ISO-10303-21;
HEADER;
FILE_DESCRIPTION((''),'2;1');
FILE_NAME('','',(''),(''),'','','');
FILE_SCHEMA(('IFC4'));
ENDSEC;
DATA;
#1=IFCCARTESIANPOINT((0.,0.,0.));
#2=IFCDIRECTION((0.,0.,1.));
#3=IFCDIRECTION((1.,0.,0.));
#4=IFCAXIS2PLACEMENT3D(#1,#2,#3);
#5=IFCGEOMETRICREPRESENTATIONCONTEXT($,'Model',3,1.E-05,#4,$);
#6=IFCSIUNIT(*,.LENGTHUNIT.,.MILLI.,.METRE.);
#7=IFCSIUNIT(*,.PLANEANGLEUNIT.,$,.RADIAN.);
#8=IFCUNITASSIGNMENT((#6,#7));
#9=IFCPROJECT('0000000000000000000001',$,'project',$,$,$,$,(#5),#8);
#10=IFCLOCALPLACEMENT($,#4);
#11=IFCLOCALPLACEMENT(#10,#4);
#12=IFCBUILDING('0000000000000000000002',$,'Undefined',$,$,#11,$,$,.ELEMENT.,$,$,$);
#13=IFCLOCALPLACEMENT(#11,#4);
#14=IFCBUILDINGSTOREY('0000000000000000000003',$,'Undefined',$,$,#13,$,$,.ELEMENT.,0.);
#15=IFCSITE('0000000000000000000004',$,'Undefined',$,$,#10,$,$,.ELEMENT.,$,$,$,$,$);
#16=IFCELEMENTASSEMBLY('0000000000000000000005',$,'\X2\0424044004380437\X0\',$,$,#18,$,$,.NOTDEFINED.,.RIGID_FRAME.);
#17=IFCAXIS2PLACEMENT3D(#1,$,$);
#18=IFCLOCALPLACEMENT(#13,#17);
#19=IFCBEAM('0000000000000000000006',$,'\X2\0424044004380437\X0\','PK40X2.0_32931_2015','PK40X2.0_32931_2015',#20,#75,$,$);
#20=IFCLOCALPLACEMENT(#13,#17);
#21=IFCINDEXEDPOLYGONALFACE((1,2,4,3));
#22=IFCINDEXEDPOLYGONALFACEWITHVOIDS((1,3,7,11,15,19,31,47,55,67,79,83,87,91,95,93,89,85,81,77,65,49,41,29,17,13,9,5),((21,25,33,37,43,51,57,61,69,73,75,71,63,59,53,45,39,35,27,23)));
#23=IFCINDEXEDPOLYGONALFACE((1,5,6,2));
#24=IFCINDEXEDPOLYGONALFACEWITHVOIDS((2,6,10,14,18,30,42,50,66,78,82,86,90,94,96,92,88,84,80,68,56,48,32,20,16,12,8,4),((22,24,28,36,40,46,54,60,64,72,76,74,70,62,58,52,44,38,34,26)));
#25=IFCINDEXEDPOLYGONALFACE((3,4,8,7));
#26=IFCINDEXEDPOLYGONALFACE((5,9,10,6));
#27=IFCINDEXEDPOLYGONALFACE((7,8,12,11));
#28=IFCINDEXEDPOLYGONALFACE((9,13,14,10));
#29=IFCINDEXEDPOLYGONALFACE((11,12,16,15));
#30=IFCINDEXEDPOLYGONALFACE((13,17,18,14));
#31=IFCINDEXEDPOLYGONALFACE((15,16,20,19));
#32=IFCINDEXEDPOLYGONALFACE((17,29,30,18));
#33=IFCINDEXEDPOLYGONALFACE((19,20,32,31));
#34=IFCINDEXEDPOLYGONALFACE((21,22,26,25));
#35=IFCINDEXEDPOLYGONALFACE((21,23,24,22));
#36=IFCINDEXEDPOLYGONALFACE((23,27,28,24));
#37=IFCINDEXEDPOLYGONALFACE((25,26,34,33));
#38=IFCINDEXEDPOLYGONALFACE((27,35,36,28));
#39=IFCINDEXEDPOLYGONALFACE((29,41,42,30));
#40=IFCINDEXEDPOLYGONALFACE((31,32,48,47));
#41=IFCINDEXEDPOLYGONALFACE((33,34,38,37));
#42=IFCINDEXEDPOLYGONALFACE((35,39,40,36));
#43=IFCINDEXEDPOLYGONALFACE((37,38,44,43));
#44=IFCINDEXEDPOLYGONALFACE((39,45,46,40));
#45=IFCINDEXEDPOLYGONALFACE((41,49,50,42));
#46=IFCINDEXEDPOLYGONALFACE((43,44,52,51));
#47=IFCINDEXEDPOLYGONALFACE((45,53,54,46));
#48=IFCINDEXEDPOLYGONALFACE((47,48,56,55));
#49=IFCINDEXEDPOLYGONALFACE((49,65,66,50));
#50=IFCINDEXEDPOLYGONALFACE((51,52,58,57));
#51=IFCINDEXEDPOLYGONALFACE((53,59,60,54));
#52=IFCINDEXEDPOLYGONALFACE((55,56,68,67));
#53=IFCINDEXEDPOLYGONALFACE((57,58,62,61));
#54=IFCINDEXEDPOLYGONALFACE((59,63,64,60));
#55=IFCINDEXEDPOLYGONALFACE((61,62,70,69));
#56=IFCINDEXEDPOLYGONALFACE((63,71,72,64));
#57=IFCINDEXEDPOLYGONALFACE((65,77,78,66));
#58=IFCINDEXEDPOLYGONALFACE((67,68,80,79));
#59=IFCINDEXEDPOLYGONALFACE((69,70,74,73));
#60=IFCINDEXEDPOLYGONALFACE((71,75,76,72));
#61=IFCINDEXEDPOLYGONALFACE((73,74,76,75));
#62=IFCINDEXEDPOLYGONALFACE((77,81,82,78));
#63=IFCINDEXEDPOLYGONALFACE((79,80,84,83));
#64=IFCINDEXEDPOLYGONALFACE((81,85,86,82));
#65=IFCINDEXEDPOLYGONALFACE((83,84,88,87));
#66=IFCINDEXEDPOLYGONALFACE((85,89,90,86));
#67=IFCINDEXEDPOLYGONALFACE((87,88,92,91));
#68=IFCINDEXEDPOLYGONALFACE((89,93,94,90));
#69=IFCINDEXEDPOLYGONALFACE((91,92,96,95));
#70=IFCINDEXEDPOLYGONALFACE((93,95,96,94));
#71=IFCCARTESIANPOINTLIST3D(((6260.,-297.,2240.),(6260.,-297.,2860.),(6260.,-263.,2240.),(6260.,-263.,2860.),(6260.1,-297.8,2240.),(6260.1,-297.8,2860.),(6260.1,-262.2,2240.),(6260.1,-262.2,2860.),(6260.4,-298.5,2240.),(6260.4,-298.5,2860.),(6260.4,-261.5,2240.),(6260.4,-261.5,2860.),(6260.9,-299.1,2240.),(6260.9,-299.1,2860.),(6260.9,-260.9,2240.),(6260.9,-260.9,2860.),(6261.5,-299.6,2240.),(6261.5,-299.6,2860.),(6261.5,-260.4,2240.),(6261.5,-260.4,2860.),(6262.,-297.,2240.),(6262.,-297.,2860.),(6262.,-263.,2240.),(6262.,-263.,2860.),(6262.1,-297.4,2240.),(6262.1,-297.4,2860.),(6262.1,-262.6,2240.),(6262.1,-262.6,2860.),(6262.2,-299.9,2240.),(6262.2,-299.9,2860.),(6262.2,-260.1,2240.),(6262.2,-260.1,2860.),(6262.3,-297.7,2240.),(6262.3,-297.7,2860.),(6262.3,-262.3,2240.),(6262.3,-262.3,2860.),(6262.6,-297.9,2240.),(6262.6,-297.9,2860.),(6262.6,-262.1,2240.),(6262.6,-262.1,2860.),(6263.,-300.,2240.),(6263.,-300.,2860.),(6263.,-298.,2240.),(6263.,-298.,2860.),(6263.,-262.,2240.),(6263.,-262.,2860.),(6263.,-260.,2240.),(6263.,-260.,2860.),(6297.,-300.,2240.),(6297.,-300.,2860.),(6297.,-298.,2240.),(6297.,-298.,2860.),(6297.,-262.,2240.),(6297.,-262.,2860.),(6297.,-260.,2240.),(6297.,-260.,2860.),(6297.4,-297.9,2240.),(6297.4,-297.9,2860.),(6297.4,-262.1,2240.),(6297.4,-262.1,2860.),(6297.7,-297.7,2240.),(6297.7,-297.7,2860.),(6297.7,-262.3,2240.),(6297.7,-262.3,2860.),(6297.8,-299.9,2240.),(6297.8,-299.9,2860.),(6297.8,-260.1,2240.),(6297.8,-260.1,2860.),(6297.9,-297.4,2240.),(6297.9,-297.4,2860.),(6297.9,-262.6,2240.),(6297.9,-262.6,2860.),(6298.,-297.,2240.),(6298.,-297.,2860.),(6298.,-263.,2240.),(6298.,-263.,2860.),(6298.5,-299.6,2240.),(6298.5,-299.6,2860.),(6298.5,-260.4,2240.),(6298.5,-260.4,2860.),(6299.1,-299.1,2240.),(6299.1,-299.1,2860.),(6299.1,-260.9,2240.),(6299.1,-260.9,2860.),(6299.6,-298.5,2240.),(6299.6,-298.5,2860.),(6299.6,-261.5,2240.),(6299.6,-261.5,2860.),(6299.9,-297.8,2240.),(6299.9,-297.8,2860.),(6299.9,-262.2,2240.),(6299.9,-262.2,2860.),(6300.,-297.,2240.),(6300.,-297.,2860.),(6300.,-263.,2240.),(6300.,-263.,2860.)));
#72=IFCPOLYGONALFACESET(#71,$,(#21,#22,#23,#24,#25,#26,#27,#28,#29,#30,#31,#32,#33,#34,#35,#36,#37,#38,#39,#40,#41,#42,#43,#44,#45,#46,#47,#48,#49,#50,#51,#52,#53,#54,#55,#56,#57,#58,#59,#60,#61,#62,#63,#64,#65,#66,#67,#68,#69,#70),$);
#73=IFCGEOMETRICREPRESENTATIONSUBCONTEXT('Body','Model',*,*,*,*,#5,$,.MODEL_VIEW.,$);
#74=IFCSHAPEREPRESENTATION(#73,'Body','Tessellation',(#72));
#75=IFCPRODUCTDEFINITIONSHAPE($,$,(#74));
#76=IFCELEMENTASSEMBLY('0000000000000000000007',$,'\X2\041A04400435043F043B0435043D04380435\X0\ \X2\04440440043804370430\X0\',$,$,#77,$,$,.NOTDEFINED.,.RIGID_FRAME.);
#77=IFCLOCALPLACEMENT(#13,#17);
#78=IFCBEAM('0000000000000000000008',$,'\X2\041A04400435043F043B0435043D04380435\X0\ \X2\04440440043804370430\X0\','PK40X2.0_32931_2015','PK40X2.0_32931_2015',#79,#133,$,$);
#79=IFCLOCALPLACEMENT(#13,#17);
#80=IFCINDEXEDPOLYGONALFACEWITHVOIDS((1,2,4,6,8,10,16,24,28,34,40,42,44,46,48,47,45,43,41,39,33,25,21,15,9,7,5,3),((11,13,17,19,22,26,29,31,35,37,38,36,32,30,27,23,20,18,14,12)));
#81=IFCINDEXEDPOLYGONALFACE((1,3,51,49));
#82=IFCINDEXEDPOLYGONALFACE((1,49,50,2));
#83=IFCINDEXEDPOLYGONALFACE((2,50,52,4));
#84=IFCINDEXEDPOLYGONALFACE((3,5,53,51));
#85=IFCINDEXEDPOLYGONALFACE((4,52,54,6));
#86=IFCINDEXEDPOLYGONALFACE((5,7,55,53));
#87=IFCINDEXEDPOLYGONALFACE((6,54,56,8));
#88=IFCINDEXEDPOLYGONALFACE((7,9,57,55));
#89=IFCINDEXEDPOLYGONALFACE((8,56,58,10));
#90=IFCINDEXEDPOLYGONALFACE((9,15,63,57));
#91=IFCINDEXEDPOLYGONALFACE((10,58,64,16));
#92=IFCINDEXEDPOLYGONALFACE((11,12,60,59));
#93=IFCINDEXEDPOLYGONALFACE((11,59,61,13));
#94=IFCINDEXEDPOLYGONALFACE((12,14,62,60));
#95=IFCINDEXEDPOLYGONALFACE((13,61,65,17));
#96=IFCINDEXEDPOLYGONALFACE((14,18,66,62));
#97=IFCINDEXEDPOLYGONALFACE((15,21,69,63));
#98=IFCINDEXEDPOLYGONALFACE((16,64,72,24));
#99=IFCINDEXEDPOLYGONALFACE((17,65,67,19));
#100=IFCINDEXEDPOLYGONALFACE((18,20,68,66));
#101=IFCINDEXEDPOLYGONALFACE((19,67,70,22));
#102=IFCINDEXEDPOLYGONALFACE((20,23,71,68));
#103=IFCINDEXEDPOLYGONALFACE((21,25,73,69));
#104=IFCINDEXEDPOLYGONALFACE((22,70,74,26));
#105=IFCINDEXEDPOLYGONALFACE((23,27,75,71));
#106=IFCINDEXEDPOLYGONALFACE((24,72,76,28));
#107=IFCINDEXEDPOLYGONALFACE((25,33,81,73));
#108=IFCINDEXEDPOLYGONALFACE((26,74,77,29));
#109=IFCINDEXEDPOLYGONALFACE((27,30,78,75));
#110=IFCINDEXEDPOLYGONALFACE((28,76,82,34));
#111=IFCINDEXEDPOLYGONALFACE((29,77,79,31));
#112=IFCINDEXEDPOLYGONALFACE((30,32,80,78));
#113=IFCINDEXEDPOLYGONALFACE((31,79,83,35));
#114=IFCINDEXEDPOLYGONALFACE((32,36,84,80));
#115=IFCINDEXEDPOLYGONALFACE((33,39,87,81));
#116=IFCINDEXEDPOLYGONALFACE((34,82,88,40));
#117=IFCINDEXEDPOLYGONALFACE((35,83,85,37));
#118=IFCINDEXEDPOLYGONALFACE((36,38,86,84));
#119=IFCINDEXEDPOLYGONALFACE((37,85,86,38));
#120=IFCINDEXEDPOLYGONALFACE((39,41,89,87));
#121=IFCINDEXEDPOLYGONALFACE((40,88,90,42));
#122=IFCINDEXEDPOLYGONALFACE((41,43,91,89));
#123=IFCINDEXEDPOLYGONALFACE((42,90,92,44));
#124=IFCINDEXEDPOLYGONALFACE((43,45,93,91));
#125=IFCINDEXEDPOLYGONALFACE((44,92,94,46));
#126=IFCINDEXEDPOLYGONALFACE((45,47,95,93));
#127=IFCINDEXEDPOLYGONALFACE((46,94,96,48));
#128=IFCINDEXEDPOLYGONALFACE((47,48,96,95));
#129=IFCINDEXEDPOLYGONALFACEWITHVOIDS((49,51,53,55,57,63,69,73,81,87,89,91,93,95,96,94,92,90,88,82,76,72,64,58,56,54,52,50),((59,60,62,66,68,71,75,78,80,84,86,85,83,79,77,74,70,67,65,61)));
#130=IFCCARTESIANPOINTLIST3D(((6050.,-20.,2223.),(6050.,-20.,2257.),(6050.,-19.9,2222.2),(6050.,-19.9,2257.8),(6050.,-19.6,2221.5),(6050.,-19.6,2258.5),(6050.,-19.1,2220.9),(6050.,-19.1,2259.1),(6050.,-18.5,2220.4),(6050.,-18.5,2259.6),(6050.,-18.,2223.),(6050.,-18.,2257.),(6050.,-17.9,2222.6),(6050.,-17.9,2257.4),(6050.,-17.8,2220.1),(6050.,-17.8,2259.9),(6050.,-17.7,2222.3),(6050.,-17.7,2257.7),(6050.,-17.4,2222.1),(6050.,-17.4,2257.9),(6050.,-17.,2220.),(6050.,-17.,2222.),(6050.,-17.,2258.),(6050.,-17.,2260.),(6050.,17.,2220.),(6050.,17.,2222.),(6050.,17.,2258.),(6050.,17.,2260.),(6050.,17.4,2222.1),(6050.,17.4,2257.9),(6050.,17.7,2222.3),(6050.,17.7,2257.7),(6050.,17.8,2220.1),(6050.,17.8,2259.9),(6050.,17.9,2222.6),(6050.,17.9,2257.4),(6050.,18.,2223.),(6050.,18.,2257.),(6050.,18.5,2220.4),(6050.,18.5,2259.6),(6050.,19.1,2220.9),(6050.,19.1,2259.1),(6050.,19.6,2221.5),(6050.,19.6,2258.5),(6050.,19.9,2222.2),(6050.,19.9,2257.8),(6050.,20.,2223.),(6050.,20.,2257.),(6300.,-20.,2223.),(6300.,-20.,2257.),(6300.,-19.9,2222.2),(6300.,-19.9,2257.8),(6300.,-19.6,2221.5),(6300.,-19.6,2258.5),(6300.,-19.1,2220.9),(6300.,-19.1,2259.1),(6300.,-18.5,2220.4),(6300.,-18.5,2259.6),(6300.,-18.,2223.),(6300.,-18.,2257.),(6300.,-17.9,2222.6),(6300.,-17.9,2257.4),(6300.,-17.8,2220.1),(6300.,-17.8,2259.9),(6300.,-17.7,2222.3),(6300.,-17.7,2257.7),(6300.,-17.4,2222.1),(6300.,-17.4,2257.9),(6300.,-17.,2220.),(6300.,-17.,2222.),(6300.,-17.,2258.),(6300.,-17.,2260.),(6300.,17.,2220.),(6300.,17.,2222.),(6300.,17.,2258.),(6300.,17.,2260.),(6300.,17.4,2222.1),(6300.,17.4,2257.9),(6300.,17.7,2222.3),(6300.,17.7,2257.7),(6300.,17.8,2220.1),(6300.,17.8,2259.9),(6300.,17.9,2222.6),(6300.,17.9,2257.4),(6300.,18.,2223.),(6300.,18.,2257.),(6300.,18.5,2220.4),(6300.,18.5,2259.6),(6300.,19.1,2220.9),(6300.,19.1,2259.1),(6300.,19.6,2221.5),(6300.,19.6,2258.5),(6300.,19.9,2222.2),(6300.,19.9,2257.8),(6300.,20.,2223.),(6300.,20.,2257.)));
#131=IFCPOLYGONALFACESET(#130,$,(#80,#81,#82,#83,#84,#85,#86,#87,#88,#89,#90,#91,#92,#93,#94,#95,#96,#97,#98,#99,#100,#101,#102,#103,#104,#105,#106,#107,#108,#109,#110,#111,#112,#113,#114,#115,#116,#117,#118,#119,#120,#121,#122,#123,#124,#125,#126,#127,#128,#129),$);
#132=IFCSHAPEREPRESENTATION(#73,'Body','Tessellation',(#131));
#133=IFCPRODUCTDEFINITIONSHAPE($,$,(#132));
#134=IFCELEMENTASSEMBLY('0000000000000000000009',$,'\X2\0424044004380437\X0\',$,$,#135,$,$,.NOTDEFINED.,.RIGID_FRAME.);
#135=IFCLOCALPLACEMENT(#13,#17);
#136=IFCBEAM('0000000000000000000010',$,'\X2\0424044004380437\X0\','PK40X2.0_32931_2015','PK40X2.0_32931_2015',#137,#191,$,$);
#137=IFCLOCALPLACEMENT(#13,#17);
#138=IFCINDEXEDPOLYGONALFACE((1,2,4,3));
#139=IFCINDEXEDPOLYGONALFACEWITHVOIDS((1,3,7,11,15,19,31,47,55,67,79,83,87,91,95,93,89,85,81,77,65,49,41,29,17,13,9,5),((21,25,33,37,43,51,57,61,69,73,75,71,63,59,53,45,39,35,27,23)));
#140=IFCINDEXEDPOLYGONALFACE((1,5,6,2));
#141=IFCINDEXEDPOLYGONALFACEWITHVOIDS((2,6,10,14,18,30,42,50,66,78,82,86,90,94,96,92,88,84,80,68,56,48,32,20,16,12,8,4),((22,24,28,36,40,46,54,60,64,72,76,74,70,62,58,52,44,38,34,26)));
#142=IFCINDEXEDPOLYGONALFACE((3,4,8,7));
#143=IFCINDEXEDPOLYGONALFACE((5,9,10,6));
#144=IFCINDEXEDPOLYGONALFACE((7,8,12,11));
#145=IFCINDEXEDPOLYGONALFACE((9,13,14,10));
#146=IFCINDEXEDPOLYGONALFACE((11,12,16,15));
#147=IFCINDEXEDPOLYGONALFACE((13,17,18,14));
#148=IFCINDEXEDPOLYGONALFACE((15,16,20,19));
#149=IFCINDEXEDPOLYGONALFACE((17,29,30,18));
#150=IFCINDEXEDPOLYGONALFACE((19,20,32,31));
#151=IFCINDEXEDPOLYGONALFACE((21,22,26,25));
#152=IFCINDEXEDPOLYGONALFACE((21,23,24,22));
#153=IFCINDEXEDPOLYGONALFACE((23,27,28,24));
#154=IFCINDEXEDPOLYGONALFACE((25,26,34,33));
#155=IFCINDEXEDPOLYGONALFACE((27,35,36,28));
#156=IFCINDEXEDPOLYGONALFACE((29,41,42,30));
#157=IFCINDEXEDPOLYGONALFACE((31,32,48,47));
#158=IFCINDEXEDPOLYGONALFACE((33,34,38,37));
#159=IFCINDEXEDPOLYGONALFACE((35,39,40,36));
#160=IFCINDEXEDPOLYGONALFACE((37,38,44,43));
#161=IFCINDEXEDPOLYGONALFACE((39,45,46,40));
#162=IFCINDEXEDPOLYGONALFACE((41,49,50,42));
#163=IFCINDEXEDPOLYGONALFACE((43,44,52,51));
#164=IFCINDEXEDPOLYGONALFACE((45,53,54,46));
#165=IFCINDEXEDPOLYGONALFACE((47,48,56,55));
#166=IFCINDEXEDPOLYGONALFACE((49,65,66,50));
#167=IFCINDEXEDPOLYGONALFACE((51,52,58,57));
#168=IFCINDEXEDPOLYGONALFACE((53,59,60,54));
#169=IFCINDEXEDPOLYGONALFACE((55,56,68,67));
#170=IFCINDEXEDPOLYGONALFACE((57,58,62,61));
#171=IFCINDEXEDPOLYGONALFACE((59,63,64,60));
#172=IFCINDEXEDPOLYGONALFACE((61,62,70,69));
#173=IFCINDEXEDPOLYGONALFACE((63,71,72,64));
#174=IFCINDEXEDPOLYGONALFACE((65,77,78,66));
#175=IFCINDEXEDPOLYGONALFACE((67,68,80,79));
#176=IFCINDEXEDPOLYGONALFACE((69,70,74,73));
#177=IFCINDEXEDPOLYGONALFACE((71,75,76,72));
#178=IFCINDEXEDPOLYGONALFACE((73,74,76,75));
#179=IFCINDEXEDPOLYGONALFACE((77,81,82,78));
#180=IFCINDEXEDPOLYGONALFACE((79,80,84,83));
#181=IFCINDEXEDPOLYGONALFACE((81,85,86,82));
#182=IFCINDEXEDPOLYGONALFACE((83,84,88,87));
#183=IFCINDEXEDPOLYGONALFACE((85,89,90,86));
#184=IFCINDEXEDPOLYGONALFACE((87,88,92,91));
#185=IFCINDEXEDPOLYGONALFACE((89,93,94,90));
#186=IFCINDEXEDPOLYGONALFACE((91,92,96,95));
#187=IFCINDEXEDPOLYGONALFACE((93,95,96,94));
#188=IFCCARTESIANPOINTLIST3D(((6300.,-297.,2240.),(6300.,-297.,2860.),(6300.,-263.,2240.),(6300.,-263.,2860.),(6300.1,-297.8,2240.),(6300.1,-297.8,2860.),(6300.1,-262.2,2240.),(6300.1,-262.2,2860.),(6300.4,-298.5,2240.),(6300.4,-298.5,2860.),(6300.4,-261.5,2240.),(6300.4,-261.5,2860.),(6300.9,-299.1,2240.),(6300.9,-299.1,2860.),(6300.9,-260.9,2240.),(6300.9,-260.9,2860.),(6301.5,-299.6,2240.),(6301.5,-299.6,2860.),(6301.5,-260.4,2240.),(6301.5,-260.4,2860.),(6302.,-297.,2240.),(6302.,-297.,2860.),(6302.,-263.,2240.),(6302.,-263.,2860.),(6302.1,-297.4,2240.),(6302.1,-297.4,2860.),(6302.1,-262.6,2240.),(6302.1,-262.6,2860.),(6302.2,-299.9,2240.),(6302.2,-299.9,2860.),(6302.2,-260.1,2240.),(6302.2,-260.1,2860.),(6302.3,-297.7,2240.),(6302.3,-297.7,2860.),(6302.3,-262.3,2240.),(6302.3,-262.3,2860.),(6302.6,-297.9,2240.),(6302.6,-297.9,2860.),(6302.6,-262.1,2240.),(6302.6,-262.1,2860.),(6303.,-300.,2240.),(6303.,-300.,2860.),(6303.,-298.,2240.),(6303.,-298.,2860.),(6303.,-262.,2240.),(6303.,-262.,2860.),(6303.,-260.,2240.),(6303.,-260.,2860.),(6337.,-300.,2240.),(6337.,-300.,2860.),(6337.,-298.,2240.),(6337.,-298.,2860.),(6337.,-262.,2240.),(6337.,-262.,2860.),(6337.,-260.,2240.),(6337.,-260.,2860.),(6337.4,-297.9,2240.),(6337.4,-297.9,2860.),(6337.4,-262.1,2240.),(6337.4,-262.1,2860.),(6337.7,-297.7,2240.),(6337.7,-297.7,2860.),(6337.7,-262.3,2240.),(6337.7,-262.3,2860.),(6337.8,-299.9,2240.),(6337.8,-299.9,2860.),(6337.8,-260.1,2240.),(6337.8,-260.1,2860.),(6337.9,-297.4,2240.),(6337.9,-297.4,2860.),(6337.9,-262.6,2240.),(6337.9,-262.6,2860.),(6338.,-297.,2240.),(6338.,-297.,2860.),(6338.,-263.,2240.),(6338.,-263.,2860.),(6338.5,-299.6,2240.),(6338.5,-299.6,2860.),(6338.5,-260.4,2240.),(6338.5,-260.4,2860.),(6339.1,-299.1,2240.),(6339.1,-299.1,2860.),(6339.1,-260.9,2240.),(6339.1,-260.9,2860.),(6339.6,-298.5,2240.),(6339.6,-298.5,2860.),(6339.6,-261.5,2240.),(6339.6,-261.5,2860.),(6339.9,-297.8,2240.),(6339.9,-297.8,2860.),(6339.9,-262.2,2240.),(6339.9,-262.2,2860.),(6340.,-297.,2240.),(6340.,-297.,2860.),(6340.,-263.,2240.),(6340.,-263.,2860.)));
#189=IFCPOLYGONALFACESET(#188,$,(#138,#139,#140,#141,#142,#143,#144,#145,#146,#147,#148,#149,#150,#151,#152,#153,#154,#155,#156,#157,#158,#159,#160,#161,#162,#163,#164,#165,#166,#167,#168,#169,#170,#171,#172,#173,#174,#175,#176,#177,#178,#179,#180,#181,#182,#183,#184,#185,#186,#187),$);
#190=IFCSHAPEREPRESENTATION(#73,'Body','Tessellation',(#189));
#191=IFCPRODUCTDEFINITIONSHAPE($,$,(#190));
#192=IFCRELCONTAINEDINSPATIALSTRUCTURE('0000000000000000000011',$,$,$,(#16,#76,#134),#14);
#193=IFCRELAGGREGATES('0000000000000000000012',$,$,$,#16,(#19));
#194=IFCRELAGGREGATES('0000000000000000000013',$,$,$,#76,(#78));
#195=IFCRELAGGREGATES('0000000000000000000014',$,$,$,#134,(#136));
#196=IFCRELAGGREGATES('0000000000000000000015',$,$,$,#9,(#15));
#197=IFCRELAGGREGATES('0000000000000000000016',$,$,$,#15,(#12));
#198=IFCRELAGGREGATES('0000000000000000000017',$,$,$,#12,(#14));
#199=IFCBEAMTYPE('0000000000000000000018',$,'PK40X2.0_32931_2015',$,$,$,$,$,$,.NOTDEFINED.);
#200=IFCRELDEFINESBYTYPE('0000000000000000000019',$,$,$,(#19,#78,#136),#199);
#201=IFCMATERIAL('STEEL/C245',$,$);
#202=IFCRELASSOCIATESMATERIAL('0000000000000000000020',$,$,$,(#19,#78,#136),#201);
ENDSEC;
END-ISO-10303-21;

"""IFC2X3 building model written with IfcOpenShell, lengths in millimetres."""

from ifc_helpers import new_model, si_unit, frame, origin_with_axes, origin_2d_with_axis, place, context, subcontext, project, spatial, hollow_rectangle, extrude, material, type_object, element, aggregate, save


model = new_model("IFC2X3")

# Units and contexts
model_context = context("Model", 3, precision=1e-05, world=origin_with_axes())
body_context = subcontext(model_context, "Body", "Model", "MODEL_VIEW")
ifc_project = project(units=[si_unit("LENGTHUNIT", "METRE", prefix="MILLI"), si_unit("PLANEANGLEUNIT", "RADIAN")], contexts=[model_context])

# Site, building, storey
site_placement = place(None, origin_with_axes())
site = spatial("IfcSite", under=ifc_project, at=site_placement, Name="Undefined", CompositionType="ELEMENT")
building_placement = place(site_placement, origin_with_axes())
building = spatial("IfcBuilding", under=site, at=building_placement, Name="Undefined", CompositionType="ELEMENT")
storey_placement = place(building_placement, origin_with_axes())
storey = spatial("IfcBuildingStorey", under=building, at=storey_placement, Name="Undefined", CompositionType="ELEMENT", Elevation=0.0)

# Shared definitions
ifc_material_1 = material(Name="STEEL/C245")

# Element assembly, beam
assembly_1_placement = place(storey_placement, origin_with_axes())
assembly_1 = element("IfcElementAssembly", 1, at=assembly_1_placement, inside=storey, Name="Фриз", AssemblyPlace="NOTDEFINED", PredefinedType="RIGID_FRAME")
beam_type_1 = type_object("IfcBeamType", Name="PK40X2.0_32931_2015", PredefinedType="NOTDEFINED")
beam_1_placement = place(assembly_1_placement, frame((6280.0, -280.0, 2860.0), z_axis=(1.0, 0.0, 0.0), x_axis=(0.0, 0.0, -1.0)))
beam_1 = element("IfcBeam", 2, at=beam_1_placement, type_object=beam_type_1, material=ifc_material_1, Name="Фриз", Description="PK40X2.0_32931_2015", ObjectType="PK40X2.0_32931_2015", context=body_context, shape_type="SweptSolid", body=[
    extrude(hollow_rectangle(XDim=40.0, YDim=40.0, WallThickness=2.0, InnerFilletRadius=1.0, OuterFilletRadius=3.0, at=origin_2d_with_axis()), frame((620.0, 0.0, 0.0), z_axis=(-1.0, 0.0, 0.0), x_axis=(0.0, -1.0, 0.0)), (0.0, 0.0, 1.0), 620.0),
])
aggregate(assembly_1, [beam_1])

# Element assembly, beam
assembly_2_placement = place(storey_placement, origin_with_axes())
assembly_2 = element("IfcElementAssembly", 3, at=assembly_2_placement, inside=storey, Name="Крепление фриза", AssemblyPlace="NOTDEFINED", PredefinedType="RIGID_FRAME")
beam_2_placement = place(assembly_2_placement, frame((6300.0, 0.0, 2240.0), z_axis=(0.0, 0.0, -1.0), x_axis=(-1.0, 0.0, 0.0)))
beam_2 = element("IfcBeam", 4, at=beam_2_placement, type_object=beam_type_1, material=ifc_material_1, Name="Крепление фриза", Description="PK40X2.0_32931_2015", ObjectType="PK40X2.0_32931_2015", context=body_context, shape_type="SweptSolid", body=[
    extrude(hollow_rectangle(XDim=40.0, YDim=40.0, WallThickness=2.0, InnerFilletRadius=1.0, OuterFilletRadius=3.0, at=origin_2d_with_axis()), frame((250.0, 0.0, 0.0), z_axis=(-1.0, 0.0, 0.0), x_axis=(0.0, -1.0, 0.0)), (0.0, 0.0, 1.0), 250.0),
])
aggregate(assembly_2, [beam_2])

# Element assembly, beam
assembly_3_placement = place(storey_placement, origin_with_axes())
assembly_3 = element("IfcElementAssembly", 5, at=assembly_3_placement, inside=storey, Name="Фриз", AssemblyPlace="NOTDEFINED", PredefinedType="RIGID_FRAME")
beam_3_placement = place(assembly_3_placement, frame((6320.0, -280.0, 2860.0), z_axis=(-1.0, 0.0, 0.0), x_axis=(0.0, 0.0, -1.0)))
beam_3 = element("IfcBeam", 6, at=beam_3_placement, type_object=beam_type_1, material=ifc_material_1, Name="Фриз", Description="PK40X2.0_32931_2015", ObjectType="PK40X2.0_32931_2015", context=body_context, shape_type="SweptSolid", body=[
    extrude(hollow_rectangle(XDim=40.0, YDim=40.0, WallThickness=2.0, InnerFilletRadius=1.0, OuterFilletRadius=3.0, at=origin_2d_with_axis()), frame((620.0, 0.0, 0.0), z_axis=(-1.0, 0.0, 0.0), x_axis=(0.0, -1.0, 0.0)), (0.0, 0.0, 1.0), 620.0),
])
aggregate(assembly_3, [beam_3])

save(model, "model.ifc")
